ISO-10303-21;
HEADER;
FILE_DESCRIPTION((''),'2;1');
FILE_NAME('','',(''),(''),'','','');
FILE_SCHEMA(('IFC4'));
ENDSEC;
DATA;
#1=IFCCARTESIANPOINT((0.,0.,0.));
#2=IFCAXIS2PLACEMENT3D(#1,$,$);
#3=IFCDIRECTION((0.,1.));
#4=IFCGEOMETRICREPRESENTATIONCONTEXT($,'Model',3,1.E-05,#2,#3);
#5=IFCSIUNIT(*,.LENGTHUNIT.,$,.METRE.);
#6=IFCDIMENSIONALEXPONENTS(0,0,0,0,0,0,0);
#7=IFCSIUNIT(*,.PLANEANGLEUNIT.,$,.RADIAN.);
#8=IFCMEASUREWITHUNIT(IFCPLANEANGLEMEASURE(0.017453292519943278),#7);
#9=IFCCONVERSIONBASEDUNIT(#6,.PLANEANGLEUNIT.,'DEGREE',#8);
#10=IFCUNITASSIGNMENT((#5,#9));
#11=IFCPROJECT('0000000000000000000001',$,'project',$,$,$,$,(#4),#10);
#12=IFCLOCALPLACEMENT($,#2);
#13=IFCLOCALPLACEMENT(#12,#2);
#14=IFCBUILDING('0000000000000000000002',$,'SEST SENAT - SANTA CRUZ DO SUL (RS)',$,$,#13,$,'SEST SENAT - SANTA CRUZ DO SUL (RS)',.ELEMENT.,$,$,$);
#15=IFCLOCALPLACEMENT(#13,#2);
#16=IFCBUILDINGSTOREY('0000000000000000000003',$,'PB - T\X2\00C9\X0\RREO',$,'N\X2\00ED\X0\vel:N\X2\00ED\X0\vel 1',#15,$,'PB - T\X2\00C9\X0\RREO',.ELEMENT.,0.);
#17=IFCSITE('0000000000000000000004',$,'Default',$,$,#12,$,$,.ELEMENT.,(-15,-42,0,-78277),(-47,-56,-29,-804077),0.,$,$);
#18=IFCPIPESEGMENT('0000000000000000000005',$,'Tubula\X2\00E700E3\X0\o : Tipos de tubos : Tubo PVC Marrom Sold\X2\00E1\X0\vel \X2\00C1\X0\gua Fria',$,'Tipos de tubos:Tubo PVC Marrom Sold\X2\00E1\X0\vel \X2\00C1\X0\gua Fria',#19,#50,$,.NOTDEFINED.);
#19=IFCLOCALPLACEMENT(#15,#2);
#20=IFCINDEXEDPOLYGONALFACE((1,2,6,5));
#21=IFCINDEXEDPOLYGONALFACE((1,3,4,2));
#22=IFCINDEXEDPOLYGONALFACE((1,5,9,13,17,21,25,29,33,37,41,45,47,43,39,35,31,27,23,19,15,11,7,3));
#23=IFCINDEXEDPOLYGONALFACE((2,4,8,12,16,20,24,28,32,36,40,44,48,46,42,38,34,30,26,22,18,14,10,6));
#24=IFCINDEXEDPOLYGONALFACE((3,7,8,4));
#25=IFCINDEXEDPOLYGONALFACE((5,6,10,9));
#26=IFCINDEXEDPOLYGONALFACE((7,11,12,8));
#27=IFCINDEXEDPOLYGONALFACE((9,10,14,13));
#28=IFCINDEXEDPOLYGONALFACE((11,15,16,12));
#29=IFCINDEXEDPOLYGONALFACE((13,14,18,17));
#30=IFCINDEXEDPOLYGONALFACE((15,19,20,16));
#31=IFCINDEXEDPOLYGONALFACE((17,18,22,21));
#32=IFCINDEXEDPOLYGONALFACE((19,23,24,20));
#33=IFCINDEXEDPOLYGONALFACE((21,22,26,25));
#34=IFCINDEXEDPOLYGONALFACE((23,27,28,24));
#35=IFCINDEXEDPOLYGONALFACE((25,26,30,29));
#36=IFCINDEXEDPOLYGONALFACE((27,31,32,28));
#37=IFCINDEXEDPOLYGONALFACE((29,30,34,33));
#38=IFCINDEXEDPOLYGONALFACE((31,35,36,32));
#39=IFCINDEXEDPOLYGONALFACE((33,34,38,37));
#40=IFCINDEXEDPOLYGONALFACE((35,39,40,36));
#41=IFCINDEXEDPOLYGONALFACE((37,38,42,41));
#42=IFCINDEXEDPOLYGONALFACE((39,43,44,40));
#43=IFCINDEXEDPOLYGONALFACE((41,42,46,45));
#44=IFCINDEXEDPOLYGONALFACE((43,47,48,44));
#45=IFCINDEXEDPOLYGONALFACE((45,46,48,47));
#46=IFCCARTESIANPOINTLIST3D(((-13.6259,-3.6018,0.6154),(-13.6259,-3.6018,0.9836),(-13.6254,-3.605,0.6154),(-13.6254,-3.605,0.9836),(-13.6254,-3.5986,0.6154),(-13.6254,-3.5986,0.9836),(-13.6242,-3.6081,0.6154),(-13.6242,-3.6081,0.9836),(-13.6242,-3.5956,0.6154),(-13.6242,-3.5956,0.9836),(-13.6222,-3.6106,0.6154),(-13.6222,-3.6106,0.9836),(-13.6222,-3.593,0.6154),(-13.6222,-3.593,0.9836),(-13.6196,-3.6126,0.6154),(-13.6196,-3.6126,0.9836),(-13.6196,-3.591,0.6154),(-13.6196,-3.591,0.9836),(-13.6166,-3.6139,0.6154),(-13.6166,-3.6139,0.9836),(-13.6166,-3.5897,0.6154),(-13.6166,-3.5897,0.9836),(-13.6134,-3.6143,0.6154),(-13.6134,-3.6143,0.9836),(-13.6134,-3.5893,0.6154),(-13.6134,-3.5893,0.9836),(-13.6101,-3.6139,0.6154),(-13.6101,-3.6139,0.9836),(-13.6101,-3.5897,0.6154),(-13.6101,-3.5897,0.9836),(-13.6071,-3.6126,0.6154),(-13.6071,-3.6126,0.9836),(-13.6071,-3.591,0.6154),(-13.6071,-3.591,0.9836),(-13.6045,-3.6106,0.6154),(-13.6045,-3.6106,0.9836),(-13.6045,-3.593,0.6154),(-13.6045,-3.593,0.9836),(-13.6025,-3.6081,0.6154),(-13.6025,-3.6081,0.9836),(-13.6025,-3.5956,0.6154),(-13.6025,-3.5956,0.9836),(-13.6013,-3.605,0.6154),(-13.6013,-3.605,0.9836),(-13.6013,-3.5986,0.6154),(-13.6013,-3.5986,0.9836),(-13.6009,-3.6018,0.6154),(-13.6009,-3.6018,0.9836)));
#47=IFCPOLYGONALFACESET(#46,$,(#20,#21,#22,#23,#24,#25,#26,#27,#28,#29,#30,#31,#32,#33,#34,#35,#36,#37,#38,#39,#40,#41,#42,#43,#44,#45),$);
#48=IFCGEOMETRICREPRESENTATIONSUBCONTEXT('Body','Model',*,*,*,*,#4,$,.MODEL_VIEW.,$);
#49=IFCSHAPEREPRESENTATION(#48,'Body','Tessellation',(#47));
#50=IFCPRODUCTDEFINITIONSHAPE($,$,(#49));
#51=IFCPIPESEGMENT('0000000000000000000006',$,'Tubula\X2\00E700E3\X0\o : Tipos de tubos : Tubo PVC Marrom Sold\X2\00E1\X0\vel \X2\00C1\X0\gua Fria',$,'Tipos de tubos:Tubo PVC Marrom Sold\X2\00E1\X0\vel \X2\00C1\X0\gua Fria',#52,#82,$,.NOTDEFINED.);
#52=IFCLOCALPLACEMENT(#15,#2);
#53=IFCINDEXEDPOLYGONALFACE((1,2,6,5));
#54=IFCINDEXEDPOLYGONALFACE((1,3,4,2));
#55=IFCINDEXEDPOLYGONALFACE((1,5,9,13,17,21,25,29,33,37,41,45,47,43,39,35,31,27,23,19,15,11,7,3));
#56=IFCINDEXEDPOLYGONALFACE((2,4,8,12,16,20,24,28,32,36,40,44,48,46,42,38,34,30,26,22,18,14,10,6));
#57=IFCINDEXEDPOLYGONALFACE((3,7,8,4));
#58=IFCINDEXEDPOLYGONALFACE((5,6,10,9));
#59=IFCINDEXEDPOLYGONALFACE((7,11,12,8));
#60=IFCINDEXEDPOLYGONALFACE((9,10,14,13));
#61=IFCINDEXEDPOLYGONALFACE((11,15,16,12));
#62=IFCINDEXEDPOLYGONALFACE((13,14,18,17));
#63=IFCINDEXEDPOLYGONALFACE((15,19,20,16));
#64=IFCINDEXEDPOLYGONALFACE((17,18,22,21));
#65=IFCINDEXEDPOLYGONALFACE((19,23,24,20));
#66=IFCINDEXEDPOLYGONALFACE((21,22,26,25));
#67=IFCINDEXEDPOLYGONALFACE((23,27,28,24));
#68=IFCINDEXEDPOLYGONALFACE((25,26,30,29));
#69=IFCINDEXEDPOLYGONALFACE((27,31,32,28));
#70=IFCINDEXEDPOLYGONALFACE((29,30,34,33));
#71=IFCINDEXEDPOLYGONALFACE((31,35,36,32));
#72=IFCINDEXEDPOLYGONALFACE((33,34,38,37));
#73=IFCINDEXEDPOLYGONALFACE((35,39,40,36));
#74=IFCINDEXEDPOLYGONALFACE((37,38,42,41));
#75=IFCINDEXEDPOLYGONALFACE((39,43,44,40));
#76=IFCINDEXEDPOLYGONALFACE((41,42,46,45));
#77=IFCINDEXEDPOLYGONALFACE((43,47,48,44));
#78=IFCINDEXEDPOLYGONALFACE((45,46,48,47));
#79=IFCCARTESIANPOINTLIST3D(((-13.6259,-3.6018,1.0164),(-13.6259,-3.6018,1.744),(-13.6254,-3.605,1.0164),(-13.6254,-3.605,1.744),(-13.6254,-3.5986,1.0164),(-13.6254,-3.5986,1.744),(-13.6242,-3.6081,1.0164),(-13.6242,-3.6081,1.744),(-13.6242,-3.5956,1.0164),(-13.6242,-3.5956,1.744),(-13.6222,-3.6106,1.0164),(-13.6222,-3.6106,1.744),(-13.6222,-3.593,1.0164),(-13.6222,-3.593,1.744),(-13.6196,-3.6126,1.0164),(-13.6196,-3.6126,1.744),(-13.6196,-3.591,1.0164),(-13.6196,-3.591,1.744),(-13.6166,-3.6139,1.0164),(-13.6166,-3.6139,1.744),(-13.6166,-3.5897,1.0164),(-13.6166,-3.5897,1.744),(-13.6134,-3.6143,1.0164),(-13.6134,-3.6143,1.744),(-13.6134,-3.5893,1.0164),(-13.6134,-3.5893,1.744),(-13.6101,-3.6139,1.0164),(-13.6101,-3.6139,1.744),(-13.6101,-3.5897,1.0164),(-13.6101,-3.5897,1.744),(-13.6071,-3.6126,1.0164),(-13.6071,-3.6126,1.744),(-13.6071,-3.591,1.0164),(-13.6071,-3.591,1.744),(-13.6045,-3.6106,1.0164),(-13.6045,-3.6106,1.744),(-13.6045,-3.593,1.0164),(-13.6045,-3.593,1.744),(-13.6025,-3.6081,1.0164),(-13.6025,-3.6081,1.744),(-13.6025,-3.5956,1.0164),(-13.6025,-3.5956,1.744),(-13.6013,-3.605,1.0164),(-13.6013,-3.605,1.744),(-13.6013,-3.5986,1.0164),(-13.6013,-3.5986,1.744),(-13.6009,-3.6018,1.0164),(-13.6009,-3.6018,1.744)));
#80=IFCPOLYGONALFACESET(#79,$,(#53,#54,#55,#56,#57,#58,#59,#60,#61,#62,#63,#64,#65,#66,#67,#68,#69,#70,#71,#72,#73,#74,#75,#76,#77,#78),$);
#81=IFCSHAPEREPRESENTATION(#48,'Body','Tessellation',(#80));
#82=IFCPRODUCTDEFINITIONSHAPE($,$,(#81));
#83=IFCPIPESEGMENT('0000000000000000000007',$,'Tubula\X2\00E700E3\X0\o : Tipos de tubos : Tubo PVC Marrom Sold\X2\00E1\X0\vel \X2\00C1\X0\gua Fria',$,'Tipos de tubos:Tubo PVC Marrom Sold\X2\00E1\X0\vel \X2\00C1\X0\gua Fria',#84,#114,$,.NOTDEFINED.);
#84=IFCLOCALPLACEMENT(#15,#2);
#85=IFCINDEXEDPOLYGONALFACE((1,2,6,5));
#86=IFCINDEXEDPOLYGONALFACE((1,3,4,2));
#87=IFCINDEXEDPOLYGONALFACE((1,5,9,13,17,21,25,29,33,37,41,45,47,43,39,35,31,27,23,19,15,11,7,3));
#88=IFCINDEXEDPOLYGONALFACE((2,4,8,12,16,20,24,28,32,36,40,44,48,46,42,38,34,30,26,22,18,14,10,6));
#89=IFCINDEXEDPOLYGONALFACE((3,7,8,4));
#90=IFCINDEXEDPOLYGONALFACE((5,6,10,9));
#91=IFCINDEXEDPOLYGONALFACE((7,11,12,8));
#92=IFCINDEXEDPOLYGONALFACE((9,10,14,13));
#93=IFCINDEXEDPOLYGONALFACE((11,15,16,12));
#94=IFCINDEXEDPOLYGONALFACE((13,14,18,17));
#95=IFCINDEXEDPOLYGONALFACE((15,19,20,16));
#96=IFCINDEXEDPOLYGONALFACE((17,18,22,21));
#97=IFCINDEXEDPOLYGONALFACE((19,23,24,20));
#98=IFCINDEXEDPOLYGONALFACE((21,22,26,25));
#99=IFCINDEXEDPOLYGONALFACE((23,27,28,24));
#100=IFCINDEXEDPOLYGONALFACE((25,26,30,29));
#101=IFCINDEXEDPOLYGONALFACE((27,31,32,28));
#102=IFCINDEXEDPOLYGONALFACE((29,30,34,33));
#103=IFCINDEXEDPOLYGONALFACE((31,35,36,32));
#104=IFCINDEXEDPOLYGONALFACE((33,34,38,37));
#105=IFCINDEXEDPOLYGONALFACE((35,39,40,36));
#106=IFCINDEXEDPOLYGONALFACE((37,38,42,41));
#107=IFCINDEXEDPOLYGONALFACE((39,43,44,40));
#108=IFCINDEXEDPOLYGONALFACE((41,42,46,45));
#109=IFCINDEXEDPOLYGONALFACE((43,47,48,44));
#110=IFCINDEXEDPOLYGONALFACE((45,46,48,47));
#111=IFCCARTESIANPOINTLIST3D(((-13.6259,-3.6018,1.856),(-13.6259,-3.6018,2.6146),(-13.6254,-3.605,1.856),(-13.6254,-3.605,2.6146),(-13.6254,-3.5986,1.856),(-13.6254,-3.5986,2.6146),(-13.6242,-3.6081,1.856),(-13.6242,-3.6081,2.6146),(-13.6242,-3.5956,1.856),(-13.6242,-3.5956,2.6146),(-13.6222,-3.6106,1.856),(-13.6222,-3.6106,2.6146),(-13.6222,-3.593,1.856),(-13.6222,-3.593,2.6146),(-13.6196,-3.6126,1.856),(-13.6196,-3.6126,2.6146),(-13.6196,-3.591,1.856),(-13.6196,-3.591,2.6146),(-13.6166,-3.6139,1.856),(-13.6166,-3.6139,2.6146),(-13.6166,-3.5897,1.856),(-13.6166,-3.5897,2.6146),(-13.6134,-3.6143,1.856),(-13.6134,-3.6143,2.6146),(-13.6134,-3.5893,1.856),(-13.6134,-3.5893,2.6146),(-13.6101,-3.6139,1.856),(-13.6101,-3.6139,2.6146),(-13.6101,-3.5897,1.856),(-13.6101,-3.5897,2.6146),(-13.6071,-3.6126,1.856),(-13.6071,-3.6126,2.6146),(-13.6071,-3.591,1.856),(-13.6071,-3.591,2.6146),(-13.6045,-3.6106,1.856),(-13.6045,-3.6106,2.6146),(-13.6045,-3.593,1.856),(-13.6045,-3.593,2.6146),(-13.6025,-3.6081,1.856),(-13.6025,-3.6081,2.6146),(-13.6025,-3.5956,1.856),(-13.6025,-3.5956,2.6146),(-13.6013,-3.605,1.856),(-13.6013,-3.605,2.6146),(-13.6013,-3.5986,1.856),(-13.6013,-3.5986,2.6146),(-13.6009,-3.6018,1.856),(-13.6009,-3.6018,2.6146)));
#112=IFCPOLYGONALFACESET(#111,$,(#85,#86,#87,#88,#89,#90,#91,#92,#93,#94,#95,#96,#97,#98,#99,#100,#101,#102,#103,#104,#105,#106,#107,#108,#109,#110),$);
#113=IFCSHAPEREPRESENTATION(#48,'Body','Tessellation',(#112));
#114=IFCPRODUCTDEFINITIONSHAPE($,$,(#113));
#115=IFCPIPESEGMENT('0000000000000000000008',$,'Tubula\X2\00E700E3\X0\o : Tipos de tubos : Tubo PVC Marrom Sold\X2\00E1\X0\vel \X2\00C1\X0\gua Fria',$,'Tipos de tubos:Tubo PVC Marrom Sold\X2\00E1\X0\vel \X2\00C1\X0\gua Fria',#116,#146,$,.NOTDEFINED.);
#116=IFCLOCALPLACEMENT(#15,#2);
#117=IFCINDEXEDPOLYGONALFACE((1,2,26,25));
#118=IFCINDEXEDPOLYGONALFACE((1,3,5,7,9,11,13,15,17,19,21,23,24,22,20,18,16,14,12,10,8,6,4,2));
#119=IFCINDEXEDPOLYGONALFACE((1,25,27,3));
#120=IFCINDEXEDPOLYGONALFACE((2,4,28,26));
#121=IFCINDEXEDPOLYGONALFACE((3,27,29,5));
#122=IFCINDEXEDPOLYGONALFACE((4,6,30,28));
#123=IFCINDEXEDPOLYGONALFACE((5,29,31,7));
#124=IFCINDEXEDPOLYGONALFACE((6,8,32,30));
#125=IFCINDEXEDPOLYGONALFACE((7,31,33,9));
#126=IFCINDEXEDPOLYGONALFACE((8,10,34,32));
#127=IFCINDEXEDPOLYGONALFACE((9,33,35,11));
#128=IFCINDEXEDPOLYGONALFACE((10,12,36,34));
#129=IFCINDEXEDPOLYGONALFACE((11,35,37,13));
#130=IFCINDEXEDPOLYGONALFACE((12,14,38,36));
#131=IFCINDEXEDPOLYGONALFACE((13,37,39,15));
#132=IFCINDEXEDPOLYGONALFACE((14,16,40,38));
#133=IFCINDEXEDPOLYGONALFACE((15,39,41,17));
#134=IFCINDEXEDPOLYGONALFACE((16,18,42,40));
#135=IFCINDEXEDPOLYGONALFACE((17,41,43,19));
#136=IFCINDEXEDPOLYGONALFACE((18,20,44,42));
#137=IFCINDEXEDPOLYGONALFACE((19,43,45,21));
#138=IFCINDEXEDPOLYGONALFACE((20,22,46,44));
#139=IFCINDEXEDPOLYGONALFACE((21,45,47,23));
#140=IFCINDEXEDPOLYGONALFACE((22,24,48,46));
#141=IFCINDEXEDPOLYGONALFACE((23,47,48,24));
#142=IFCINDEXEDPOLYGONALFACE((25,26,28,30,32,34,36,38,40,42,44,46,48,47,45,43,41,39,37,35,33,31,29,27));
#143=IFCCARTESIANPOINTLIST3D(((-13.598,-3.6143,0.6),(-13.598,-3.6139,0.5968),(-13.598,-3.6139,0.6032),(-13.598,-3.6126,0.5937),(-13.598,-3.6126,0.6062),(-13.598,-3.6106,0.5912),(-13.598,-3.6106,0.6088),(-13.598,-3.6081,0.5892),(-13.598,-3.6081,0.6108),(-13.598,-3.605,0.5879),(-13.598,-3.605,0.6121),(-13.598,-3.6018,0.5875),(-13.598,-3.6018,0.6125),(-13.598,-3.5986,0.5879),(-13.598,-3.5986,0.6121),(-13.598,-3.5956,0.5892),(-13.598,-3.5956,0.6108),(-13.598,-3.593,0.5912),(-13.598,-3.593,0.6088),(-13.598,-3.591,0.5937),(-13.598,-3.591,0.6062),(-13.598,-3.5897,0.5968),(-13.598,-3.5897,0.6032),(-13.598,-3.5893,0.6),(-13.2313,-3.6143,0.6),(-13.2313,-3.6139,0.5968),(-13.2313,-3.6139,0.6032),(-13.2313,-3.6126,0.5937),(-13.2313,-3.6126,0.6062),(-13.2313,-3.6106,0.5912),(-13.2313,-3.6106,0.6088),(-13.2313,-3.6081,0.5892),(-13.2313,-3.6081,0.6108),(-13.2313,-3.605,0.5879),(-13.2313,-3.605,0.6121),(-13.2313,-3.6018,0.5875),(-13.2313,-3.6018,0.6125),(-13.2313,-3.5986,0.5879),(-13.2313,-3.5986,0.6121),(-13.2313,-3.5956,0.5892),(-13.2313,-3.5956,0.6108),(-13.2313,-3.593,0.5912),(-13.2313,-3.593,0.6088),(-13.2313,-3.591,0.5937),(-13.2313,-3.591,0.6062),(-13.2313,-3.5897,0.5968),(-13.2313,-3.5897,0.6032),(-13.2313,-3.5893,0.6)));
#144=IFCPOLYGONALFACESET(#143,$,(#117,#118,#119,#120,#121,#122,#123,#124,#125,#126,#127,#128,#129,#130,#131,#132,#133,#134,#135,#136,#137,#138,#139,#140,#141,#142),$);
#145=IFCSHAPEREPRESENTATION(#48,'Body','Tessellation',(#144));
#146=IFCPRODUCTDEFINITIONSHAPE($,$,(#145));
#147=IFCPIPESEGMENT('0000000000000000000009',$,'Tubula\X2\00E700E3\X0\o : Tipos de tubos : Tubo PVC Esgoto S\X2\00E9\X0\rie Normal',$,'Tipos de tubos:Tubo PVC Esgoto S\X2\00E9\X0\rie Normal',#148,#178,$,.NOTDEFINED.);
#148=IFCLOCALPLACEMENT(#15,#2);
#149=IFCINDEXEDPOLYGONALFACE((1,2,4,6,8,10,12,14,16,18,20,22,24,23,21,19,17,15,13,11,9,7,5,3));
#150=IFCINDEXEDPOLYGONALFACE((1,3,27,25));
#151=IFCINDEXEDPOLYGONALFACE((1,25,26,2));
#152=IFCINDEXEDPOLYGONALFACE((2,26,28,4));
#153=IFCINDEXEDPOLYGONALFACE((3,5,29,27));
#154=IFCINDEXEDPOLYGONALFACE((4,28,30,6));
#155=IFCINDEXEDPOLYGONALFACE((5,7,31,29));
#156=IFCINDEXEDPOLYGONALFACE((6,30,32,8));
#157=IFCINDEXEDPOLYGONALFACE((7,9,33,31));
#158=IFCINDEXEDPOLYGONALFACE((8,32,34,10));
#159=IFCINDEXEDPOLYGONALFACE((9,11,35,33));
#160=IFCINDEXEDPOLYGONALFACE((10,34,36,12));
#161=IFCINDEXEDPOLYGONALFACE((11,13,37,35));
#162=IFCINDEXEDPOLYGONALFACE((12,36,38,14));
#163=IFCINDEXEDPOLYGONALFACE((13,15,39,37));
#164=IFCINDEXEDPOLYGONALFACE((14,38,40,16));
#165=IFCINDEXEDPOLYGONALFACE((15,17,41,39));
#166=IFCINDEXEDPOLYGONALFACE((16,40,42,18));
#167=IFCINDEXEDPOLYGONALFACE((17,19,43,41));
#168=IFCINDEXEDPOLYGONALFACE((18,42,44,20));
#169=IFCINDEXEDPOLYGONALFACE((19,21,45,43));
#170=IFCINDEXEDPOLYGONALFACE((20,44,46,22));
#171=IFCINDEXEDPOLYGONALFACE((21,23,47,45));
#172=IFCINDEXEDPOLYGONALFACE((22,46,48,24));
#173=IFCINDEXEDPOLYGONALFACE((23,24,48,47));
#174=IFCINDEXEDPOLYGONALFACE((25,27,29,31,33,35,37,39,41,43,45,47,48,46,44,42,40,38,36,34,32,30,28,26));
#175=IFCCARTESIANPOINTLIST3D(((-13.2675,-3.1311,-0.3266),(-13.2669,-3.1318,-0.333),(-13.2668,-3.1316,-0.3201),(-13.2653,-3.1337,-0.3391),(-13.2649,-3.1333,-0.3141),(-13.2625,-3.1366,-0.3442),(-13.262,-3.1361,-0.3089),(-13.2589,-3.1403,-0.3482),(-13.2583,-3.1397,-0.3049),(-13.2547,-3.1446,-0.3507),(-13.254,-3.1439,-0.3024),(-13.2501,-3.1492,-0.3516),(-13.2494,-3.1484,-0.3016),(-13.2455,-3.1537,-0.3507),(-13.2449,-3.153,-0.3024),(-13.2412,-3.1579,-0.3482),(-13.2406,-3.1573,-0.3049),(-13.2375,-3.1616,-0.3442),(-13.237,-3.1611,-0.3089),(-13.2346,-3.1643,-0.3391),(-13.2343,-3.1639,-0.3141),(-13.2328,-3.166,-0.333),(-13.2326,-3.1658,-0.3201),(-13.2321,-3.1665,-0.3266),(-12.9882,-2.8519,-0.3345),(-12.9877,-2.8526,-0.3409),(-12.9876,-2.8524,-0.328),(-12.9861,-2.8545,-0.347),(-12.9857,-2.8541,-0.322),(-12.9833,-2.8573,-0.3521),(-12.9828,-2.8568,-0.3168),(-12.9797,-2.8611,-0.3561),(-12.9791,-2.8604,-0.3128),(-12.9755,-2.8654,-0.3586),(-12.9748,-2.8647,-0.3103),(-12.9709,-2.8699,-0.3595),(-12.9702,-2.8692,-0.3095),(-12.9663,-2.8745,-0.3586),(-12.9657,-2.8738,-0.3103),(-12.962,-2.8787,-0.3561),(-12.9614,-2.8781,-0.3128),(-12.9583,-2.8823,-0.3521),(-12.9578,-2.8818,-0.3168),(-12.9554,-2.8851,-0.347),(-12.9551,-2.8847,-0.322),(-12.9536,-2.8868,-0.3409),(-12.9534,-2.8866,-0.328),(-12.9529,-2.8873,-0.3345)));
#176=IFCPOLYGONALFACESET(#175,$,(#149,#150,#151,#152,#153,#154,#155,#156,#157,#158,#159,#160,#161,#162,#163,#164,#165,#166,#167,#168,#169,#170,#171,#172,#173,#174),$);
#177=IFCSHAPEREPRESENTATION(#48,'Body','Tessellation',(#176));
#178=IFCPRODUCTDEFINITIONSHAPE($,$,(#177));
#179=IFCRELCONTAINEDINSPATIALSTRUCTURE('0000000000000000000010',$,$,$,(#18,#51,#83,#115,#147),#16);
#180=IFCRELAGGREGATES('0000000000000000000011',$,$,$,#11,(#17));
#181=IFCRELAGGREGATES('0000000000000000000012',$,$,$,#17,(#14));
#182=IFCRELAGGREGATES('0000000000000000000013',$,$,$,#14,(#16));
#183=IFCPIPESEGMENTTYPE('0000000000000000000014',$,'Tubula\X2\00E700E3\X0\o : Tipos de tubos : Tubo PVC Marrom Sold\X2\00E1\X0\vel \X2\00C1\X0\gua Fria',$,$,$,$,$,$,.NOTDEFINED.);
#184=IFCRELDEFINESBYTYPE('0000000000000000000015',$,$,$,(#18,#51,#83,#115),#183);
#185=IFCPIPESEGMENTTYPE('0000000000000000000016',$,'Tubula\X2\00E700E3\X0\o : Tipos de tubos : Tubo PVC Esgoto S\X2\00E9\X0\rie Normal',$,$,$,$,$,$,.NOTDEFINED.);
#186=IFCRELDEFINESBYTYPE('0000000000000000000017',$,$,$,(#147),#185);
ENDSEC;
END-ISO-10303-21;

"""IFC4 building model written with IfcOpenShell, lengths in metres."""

from ifc_helpers import new_model, entity, si_unit, converted_unit, direction, frame, origin, place, context, subcontext, project, spatial, arc, indexed_curve, outline, extrude, type_object, element, save


model = new_model("IFC4")

# Units and contexts
model_context = context("Model", 3, precision=1e-05, world=origin(), true_north=direction((0.0, 1.0)))
body_context = subcontext(model_context, "Body", "Model", "MODEL_VIEW")
ifc_project = project(units=[si_unit("LENGTHUNIT", "METRE"), converted_unit("PLANEANGLEUNIT", "DEGREE", entity("IfcPlaneAngleMeasure", 0.017453292519943278), si_unit("PLANEANGLEUNIT", "RADIAN"), dimensions=[0, 0, 0, 0, 0, 0, 0])], contexts=[model_context])

# Site, building, storey
site_placement = place(None, origin())
site = spatial("IfcSite", under=ifc_project, at=site_placement, Name="Default", CompositionType="ELEMENT", RefLatitude=(-15, -42, 0, -78277), RefLongitude=(-47, -56, -29, -804077), RefElevation=0.0)
building_placement = place(site_placement, origin())
building = spatial("IfcBuilding", under=site, at=building_placement, Name="SEST SENAT - SANTA CRUZ DO SUL (RS)", LongName="SEST SENAT - SANTA CRUZ DO SUL (RS)", CompositionType="ELEMENT")
storey_placement = place(building_placement, origin())
storey = spatial("IfcBuildingStorey", under=building, at=storey_placement, Name="PB - TÉRREO", ObjectType="Nível:Nível 1", LongName="PB - TÉRREO", CompositionType="ELEMENT", Elevation=0.0)

# Pipe segments
pipe_segment_type_1 = type_object("IfcPipeSegmentType", Name="Tubulação : Tipos de tubos : Tubo PVC Marrom Soldável Água Fria", PredefinedType="NOTDEFINED")
pipe_segment_1_placement = place(storey_placement, frame((-13.6275, -3.6159, 0.6154)))
element("IfcPipeSegment", 1, at=pipe_segment_1_placement, inside=storey, type_object=pipe_segment_type_1, Name="Tubulação : Tipos de tubos : Tubo PVC Marrom Soldável Água Fria", ObjectType="Tipos de tubos:Tubo PVC Marrom Soldável Água Fria", PredefinedType="NOTDEFINED", context=body_context, shape_type="SweptSolid", body=[
    extrude(outline(indexed_curve([(0.0125, 0.0), (0.0088, 0.0088), (0.0, 0.0125), (-0.0088, 0.0088), (-0.0125, 0.0), (-0.0088, -0.0088), (0.0, -0.0125), (0.0088, -0.0088)], segments=[arc(1, 2, 3), arc(3, 4, 5), arc(5, 6, 7), arc(7, 8, 1)], self_intersect=False)), frame((0.0141, 0.0141, 0.0)), (0.0, 0.0, 1.0), 0.3682),
])
pipe_segment_2_placement = place(storey_placement, frame((-13.6275, -3.6159, 1.0164)))
element("IfcPipeSegment", 2, at=pipe_segment_2_placement, inside=storey, type_object=pipe_segment_type_1, Name="Tubulação : Tipos de tubos : Tubo PVC Marrom Soldável Água Fria", ObjectType="Tipos de tubos:Tubo PVC Marrom Soldável Água Fria", PredefinedType="NOTDEFINED", context=body_context, shape_type="SweptSolid", body=[
    extrude(outline(indexed_curve([(0.0125, 0.0), (0.0088, 0.0088), (0.0, 0.0125), (-0.0088, 0.0088), (-0.0125, 0.0), (-0.0088, -0.0088), (0.0, -0.0125), (0.0088, -0.0088)], segments=[arc(1, 2, 3), arc(3, 4, 5), arc(5, 6, 7), arc(7, 8, 1)], self_intersect=False)), frame((0.0141, 0.0141, 0.0)), (0.0, 0.0, 1.0), 0.7276),
])
pipe_segment_3_placement = place(storey_placement, frame((-13.6275, -3.6159, 1.856)))
element("IfcPipeSegment", 3, at=pipe_segment_3_placement, inside=storey, type_object=pipe_segment_type_1, Name="Tubulação : Tipos de tubos : Tubo PVC Marrom Soldável Água Fria", ObjectType="Tipos de tubos:Tubo PVC Marrom Soldável Água Fria", PredefinedType="NOTDEFINED", context=body_context, shape_type="SweptSolid", body=[
    extrude(outline(indexed_curve([(0.0125, 0.0), (0.0088, 0.0088), (0.0, 0.0125), (-0.0088, 0.0088), (-0.0125, 0.0), (-0.0088, -0.0088), (0.0, -0.0125), (0.0088, -0.0088)], segments=[arc(1, 2, 3), arc(3, 4, 5), arc(5, 6, 7), arc(7, 8, 1)], self_intersect=False)), frame((0.0141, 0.0141, 0.0)), (0.0, 0.0, 1.0), 0.7586),
])
pipe_segment_4_placement = place(storey_placement, frame((-13.598, -3.6159, 0.5859)))
element("IfcPipeSegment", 4, at=pipe_segment_4_placement, inside=storey, type_object=pipe_segment_type_1, Name="Tubulação : Tipos de tubos : Tubo PVC Marrom Soldável Água Fria", ObjectType="Tipos de tubos:Tubo PVC Marrom Soldável Água Fria", PredefinedType="NOTDEFINED", context=body_context, shape_type="SweptSolid", body=[
    extrude(outline(indexed_curve([(0.0125, 0.0), (0.0088, 0.0088), (0.0, 0.0125), (-0.0088, 0.0088), (-0.0125, 0.0), (-0.0088, -0.0088), (0.0, -0.0125), (0.0088, -0.0088)], segments=[arc(1, 2, 3), arc(3, 4, 5), arc(5, 6, 7), arc(7, 8, 1)], self_intersect=False)), frame((0.0, 0.0141, 0.0141), z_axis=(1.0, 0.0, 0.0), x_axis=(0.0, -1.0, 0.0)), (0.0, 0.0, 1.0), 0.3666),
])
pipe_segment_type_2 = type_object("IfcPipeSegmentType", Name="Tubulação : Tipos de tubos : Tubo PVC Esgoto Série Normal", PredefinedType="NOTDEFINED")
pipe_segment_5_placement = place(storey_placement, frame((-13.2691, -3.1681, -0.3)))
element("IfcPipeSegment", 5, at=pipe_segment_5_placement, inside=storey, type_object=pipe_segment_type_2, Name="Tubulação : Tipos de tubos : Tubo PVC Esgoto Série Normal", ObjectType="Tipos de tubos:Tubo PVC Esgoto Série Normal", PredefinedType="NOTDEFINED", context=body_context, shape_type="SweptSolid", body=[
    extrude(outline(indexed_curve([(0.025, 0.0), (0.0177, 0.0177), (0.0, 0.025), (-0.0177, 0.0177), (-0.025, 0.0), (-0.0177, -0.0177), (0.0, -0.025), (0.0177, -0.0177)], segments=[arc(1, 2, 3), arc(3, 4, 5), arc(5, 6, 7), arc(7, 8, 1)], self_intersect=False)), frame((0.2985, 0.2985, -0.0345), z_axis=(-0.706965, -0.706965, 0.019996), x_axis=(-0.707107, 0.707107, 0.0)), (0.0, 0.0, 1.0), 0.3949),
])

save(model, "model.ifc")
